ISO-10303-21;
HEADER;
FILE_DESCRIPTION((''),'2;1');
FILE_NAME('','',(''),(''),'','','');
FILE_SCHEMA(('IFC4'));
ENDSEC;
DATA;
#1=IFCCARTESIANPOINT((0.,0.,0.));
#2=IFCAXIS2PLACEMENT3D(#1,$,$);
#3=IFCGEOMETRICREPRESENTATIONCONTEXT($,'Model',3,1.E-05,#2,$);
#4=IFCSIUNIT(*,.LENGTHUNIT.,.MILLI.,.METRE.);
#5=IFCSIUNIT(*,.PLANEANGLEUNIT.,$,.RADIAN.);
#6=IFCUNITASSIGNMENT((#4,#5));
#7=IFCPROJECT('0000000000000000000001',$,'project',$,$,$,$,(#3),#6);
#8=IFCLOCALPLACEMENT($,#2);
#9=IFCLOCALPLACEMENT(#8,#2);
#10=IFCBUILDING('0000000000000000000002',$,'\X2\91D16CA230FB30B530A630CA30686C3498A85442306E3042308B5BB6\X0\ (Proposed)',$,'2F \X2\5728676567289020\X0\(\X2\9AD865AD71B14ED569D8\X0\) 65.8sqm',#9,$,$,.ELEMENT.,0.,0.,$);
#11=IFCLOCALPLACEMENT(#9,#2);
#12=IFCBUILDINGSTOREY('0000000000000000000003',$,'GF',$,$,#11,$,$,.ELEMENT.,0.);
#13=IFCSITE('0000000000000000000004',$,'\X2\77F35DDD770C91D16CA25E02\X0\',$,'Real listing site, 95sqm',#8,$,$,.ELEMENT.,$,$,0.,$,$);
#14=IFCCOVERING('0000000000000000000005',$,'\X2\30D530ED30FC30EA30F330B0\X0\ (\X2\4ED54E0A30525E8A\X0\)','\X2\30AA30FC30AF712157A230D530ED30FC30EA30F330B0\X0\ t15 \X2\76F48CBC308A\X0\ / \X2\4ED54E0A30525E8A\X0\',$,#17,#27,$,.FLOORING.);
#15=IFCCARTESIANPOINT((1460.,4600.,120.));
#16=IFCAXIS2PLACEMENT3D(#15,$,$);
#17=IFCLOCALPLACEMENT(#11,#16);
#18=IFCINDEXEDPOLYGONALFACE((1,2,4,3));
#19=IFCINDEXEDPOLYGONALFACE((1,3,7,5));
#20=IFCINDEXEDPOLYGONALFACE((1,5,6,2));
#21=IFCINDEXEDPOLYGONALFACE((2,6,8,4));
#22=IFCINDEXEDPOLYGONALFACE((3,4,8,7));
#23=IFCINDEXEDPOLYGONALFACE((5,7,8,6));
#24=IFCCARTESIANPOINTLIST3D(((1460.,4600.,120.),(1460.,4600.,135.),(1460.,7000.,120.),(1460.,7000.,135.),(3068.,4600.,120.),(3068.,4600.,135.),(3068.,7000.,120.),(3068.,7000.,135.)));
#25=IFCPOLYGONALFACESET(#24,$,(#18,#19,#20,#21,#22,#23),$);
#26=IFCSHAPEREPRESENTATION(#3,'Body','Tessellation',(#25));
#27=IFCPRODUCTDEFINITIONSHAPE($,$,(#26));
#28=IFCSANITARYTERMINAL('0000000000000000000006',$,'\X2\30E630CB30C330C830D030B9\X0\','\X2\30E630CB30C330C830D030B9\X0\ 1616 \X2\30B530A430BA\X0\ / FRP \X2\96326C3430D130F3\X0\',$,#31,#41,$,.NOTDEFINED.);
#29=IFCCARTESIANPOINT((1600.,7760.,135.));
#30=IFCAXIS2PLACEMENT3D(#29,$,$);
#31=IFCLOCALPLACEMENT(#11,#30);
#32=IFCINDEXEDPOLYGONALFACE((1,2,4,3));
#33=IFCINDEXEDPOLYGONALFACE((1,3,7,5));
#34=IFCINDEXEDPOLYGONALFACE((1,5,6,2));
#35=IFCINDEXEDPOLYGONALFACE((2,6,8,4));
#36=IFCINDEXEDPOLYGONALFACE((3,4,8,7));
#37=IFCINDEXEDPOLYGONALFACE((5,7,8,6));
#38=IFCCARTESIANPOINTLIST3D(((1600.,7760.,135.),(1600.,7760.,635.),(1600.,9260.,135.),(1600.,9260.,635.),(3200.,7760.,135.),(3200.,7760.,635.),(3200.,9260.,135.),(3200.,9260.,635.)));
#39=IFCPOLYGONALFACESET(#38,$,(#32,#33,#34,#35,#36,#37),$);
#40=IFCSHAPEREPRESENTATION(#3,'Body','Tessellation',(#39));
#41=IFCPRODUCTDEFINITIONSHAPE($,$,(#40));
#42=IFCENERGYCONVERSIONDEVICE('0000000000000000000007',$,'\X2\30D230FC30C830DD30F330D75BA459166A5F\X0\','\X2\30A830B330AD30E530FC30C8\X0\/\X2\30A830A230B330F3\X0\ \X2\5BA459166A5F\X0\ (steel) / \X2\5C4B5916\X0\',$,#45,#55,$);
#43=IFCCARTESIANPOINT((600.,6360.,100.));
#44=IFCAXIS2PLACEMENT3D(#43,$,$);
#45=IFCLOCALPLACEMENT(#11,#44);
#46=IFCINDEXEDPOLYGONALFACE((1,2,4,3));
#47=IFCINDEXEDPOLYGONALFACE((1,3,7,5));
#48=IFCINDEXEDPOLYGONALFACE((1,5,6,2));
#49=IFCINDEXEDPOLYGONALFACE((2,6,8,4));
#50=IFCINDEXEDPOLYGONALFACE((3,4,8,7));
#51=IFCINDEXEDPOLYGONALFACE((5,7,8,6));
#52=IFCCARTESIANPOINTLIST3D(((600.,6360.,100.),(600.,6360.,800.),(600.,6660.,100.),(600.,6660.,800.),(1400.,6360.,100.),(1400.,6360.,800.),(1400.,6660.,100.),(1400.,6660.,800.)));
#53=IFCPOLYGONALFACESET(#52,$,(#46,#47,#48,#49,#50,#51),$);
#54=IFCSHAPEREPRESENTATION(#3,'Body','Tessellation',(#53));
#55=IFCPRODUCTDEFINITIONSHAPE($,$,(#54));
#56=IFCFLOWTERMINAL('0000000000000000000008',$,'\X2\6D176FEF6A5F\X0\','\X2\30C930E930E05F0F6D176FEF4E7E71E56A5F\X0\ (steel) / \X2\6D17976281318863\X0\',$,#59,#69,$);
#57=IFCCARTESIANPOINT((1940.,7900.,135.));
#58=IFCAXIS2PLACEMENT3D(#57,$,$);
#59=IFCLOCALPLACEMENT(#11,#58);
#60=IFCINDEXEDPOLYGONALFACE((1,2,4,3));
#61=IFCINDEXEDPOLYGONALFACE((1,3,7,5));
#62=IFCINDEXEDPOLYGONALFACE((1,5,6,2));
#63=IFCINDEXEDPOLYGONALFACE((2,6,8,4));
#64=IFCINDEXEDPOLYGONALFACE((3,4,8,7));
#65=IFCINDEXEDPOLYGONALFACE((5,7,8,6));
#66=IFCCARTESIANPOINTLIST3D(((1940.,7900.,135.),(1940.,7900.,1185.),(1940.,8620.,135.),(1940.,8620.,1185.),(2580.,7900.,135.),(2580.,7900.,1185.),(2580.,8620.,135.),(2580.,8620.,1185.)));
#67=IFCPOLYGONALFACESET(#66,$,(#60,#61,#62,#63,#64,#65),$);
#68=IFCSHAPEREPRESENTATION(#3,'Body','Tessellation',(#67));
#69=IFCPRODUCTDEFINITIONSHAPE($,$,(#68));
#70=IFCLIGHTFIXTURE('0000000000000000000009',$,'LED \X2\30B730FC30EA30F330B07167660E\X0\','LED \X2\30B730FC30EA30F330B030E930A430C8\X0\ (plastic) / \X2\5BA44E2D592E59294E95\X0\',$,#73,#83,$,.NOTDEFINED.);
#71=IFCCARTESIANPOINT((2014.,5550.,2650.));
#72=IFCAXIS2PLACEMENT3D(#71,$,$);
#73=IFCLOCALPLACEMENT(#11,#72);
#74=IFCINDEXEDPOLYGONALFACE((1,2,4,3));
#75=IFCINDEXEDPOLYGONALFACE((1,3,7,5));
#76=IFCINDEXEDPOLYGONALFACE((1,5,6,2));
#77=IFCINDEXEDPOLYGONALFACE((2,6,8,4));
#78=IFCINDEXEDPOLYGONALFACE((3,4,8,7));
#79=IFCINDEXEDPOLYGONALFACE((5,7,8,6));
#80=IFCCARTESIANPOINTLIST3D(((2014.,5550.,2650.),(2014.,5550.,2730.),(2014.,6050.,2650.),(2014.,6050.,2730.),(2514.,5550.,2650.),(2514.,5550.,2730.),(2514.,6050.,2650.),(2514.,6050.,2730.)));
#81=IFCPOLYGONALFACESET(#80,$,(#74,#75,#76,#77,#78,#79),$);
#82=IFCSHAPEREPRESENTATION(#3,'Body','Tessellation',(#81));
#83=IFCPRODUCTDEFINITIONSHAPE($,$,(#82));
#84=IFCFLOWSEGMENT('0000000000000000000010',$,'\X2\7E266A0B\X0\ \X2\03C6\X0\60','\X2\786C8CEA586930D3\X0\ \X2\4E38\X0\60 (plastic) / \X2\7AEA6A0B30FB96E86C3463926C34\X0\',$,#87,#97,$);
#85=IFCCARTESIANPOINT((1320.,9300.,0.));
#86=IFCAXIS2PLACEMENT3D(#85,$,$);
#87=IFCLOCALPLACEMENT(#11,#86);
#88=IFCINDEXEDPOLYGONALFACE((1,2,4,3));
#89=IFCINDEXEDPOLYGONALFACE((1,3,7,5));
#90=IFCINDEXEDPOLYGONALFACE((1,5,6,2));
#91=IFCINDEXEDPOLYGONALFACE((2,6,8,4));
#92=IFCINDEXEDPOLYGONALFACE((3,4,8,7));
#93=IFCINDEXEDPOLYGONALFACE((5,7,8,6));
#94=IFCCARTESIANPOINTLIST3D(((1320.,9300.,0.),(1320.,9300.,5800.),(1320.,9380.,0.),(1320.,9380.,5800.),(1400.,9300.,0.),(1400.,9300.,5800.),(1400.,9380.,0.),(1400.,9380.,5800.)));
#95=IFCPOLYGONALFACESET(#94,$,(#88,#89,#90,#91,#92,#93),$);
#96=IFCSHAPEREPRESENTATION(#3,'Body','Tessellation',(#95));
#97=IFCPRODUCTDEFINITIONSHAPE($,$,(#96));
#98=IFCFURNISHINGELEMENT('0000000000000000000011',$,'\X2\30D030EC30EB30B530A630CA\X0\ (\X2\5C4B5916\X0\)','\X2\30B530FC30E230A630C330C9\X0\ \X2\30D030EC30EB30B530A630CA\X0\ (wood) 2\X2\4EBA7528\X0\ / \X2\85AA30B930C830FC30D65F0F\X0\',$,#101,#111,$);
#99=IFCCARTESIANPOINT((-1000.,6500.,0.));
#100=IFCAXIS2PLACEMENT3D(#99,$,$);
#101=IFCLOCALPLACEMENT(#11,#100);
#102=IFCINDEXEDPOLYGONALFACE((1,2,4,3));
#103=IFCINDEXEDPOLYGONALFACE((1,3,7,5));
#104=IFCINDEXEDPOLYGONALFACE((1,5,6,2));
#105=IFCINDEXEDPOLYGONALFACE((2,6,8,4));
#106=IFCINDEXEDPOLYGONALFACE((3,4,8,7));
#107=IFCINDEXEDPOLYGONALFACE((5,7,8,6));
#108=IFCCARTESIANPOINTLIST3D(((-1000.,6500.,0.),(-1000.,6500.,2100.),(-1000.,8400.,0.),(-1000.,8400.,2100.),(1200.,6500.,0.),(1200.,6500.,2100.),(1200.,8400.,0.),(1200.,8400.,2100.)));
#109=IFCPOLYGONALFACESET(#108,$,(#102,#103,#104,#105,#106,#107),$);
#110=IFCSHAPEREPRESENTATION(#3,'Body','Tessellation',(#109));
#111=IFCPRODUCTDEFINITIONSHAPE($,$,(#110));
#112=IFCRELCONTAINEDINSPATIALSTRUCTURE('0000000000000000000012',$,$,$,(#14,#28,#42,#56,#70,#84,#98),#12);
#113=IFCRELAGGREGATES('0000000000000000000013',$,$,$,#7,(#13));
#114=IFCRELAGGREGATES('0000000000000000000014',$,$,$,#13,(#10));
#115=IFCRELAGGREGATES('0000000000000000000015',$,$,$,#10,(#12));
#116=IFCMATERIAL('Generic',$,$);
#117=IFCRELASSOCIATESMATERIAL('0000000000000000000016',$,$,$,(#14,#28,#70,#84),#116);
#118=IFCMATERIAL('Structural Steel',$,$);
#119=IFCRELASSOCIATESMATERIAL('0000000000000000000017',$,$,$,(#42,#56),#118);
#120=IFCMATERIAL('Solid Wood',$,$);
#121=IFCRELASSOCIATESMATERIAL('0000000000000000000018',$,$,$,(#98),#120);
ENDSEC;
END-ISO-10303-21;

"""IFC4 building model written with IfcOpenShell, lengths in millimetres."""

from ifc_helpers import new_model, si_unit, frame, frame_2d, origin, place, context, project, spatial, rectangle, extrude, material, element, save


model = new_model("IFC4")

# Units and contexts
model_context = context("Model", 3, precision=1e-05, world=origin())
ifc_project = project(units=[si_unit("LENGTHUNIT", "METRE", prefix="MILLI"), si_unit("PLANEANGLEUNIT", "RADIAN")], contexts=[model_context])

# Site, building, storey
site_placement = place(None, origin())
site = spatial("IfcSite", under=ifc_project, at=site_placement, Name="石川県金沢市", ObjectType="Real listing site, 95sqm", CompositionType="ELEMENT", RefElevation=0.0)
building_placement = place(site_placement, origin())
building = spatial("IfcBuilding", under=site, at=building_placement, Name="金沢・サウナと水風呂のある家 (Proposed)", ObjectType="2F 在来木造(高断熱仕様) 65.8sqm", CompositionType="ELEMENT", ElevationOfRefHeight=0.0, ElevationOfTerrain=0.0)
storey_placement = place(building_placement, origin())
storey = spatial("IfcBuildingStorey", under=building, at=storey_placement, Name="GF", CompositionType="ELEMENT", Elevation=0.0)

# Shared definitions
ifc_material_1 = material(Name="Solid Wood")

# Covering
ifc_material_2 = material(Name="Generic")
covering_1_placement = place(storey_placement, frame((1460.0, 4600.0, 120.0)))
element("IfcCovering", 1, at=covering_1_placement, inside=storey, material=ifc_material_2, Name="フローリング (仕上げ床)", Description="オーク無垢フローリング t15 直貼り / 仕上げ床", PredefinedType="FLOORING", context=model_context, shape_type="SweptSolid", body=[
    extrude(rectangle(XDim=1608.0, YDim=2400.0, at=frame_2d((804.0, 1200.0))), frame((1460.0, 4600.0, 120.0)), (0.0, 0.0, 1.0), 15.0),
])

# Sanitary terminal
sanitary_terminal_placement = place(storey_placement, frame((1600.0, 7760.0, 135.0)))
element("IfcSanitaryTerminal", 2, at=sanitary_terminal_placement, inside=storey, material=ifc_material_2, Name="ユニットバス", Description="ユニットバス 1616 サイズ / FRP 防水パン", PredefinedType="NOTDEFINED", context=model_context, shape_type="SweptSolid", body=[
    extrude(rectangle(XDim=1600.0, YDim=1500.0, at=frame_2d((800.0, 750.0))), frame((1600.0, 7760.0, 135.0)), (0.0, 0.0, 1.0), 500.0),
])

# Shared definitions
ifc_material_3 = material(Name="Structural Steel")

# Energy conversion device
energy_conversion_device_placement = place(storey_placement, frame((600.0, 6360.0, 100.0)))
element("IfcEnergyConversionDevice", 3, at=energy_conversion_device_placement, inside=storey, material=ifc_material_3, Name="ヒートポンプ室外機", Description="エコキュート/エアコン 室外機 (steel) / 屋外", context=model_context, shape_type="SweptSolid", body=[
    extrude(rectangle(XDim=800.0, YDim=300.0, at=frame_2d((400.0, 150.0))), frame((600.0, 6360.0, 100.0)), (0.0, 0.0, 1.0), 700.0),
])

# Flow terminal
flow_terminal_placement = place(storey_placement, frame((1940.0, 7900.0, 135.0)))
element("IfcFlowTerminal", 4, at=flow_terminal_placement, inside=storey, material=ifc_material_3, Name="洗濯機", Description="ドラム式洗濯乾燥機 (steel) / 洗面脱衣", context=model_context, shape_type="SweptSolid", body=[
    extrude(rectangle(XDim=640.0, YDim=720.0, at=frame_2d((320.0, 360.0))), frame((1940.0, 7900.0, 135.0)), (0.0, 0.0, 1.0), 1050.0),
])

# Light fixture
light_fixture_placement = place(storey_placement, frame((2014.0, 5550.0, 2650.0)))
element("IfcLightFixture", 5, at=light_fixture_placement, inside=storey, material=ifc_material_2, Name="LED シーリング照明", Description="LED シーリングライト (plastic) / 室中央天井", PredefinedType="NOTDEFINED", context=model_context, shape_type="SweptSolid", body=[
    extrude(rectangle(XDim=500.0, YDim=500.0, at=frame_2d((250.0, 250.0))), frame((2014.0, 5550.0, 2650.0)), (0.0, 0.0, 1.0), 80.0),
])

# Flow segment
flow_segment_placement = place(storey_placement, frame((1320.0, 9300.0, 0.0)))
element("IfcFlowSegment", 6, at=flow_segment_placement, inside=storey, material=ifc_material_2, Name="縦樋 φ60", Description="硬質塩ビ 丸60 (plastic) / 竪樋・雨水排水", context=model_context, shape_type="SweptSolid", body=[
    extrude(rectangle(XDim=80.0, YDim=80.0, at=frame_2d((40.0, 40.0))), frame((1320.0, 9300.0, 0.0)), (0.0, 0.0, 1.0), 5800.0),
])

# Furnishing element
furnishing_placement = place(storey_placement, frame((-1000.0, 6500.0, 0.0)))
element("IfcFurnishingElement", 7, at=furnishing_placement, inside=storey, material=ifc_material_1, Name="バレルサウナ (屋外)", Description="サーモウッド バレルサウナ (wood) 2人用 / 薪ストーブ式", context=model_context, shape_type="SweptSolid", body=[
    extrude(rectangle(XDim=2200.0, YDim=1900.0, at=frame_2d((1100.0, 950.0))), frame((-1000.0, 6500.0, 0.0)), (0.0, 0.0, 1.0), 2100.0),
])

save(model, "model.ifc")
